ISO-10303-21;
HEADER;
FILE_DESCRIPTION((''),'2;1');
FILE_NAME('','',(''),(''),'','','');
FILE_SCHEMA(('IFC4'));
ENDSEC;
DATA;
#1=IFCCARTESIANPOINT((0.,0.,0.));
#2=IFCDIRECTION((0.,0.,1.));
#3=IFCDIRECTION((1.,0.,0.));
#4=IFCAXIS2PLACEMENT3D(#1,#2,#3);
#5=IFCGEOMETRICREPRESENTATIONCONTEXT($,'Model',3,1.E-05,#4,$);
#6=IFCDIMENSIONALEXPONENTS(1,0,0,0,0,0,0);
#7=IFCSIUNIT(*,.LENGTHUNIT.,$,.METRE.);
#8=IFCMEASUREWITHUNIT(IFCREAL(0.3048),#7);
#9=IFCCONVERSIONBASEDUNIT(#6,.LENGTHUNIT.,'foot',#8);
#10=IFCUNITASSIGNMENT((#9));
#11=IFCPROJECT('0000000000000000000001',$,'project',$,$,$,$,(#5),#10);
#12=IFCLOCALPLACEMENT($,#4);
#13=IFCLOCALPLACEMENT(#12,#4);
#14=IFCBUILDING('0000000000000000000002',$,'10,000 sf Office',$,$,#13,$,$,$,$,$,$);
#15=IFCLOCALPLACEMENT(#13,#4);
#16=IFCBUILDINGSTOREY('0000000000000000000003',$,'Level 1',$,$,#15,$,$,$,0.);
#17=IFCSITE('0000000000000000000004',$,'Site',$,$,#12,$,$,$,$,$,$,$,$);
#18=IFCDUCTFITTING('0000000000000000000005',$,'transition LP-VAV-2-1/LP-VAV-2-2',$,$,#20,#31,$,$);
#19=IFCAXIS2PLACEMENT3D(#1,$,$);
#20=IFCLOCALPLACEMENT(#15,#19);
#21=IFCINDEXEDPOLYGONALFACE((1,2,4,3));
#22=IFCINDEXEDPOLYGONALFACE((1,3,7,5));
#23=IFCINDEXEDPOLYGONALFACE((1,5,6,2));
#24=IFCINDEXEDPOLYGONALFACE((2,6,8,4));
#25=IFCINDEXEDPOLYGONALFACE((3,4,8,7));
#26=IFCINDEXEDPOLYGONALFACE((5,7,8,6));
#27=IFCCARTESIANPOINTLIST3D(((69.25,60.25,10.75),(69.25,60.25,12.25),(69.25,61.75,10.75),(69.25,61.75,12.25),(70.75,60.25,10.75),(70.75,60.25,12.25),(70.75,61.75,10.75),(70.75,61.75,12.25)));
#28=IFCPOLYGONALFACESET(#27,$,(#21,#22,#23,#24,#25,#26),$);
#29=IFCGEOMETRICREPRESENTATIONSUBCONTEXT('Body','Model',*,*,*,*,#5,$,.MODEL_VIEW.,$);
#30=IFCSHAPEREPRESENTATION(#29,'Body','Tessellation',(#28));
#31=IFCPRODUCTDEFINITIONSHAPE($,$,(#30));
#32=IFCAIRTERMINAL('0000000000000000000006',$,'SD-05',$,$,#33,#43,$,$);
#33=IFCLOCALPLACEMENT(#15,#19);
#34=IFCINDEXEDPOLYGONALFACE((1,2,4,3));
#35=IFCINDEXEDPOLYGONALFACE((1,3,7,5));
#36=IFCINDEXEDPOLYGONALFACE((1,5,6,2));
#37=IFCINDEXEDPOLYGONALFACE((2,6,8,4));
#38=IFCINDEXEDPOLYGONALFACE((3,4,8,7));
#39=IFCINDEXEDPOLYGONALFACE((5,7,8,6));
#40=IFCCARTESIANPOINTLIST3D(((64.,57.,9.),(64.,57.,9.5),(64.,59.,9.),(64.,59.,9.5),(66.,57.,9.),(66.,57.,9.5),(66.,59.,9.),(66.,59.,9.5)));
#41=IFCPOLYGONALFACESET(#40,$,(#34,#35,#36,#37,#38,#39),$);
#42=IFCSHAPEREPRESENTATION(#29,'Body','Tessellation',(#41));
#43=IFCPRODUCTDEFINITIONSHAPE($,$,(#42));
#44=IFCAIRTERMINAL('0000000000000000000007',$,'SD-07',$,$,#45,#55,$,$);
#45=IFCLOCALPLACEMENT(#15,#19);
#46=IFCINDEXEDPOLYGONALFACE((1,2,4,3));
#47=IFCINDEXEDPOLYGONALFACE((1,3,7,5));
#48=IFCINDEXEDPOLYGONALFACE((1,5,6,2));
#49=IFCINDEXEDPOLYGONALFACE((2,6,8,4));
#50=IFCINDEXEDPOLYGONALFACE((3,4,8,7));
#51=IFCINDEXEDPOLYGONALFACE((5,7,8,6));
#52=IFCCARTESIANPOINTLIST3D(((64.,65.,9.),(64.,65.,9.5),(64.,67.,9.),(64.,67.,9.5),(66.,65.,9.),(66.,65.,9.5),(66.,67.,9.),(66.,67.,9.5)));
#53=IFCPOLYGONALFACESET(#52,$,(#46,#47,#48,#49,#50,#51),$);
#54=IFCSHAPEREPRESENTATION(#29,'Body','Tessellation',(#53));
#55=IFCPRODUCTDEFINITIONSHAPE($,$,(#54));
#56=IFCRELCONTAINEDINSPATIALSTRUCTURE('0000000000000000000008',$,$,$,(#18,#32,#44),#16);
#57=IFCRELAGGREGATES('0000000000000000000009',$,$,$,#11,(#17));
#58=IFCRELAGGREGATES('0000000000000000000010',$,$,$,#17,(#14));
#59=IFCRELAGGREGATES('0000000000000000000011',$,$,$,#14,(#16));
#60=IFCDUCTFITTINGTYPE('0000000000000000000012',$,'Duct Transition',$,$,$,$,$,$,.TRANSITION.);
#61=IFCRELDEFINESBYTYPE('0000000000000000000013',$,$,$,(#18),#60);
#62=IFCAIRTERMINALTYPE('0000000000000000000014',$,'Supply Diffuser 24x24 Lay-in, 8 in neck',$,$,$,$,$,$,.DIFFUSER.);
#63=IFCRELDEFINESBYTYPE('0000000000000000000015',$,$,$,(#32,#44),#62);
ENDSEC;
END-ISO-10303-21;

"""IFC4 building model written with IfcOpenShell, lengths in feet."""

from ifc_helpers import new_model, entity, si_unit, converted_unit, frame, origin_with_axes, place, context, subcontext, project, spatial, rectangle, extrude, type_object, element, save


model = new_model("IFC4")

# Units and contexts
model_context = context("Model", 3, precision=1e-05, world=origin_with_axes())
body_context = subcontext(model_context, "Body", "Model", "MODEL_VIEW")
ifc_project = project(units=[converted_unit("LENGTHUNIT", "foot", entity("IfcReal", 0.3048), si_unit("LENGTHUNIT", "METRE"), dimensions=[1, 0, 0, 0, 0, 0, 0])], contexts=[model_context])

# Site, building, storey
site_placement = place(None, origin_with_axes())
site = spatial("IfcSite", under=ifc_project, at=site_placement, Name="Site")
building_placement = place(site_placement, origin_with_axes())
building = spatial("IfcBuilding", under=site, at=building_placement, Name="10,000 sf Office")
storey_placement = place(building_placement, origin_with_axes())
storey = spatial("IfcBuildingStorey", under=building, at=storey_placement, Name="Level 1", Elevation=0.0)

# Duct fitting
duct_fitting_type_1 = type_object("IfcDuctFittingType", Name="Duct Transition", PredefinedType="TRANSITION")
duct_fitting_1_placement = place(storey_placement, frame((70.0, 61.0, 10.75), z_axis=(0.0, 0.0, 1.0), x_axis=(1.0, 0.0, 0.0)))
element("IfcDuctFitting", 1, at=duct_fitting_1_placement, inside=storey, type_object=duct_fitting_type_1, Name="transition LP-VAV-2-1/LP-VAV-2-2", context=body_context, shape_type="SweptSolid", body=[
    extrude(rectangle(XDim=1.5, YDim=1.5), None, (0.0, 0.0, 1.0), 1.5),
])

# Air terminals
air_terminal_type = type_object("IfcAirTerminalType", Name="Supply Diffuser 24x24 Lay-in, 8 in neck", PredefinedType="DIFFUSER")
for number, where, z_axis, x_axis, name in (
    (2, (65.0, 58.0, 9.0), (0.0, 0.0, 1.0), (1.0, 0.0, 0.0), "SD-05"),
    (3, (65.0, 66.0, 9.0), (0.0, 0.0, 1.0), (1.0, 0.0, 0.0), "SD-07"),
):
    element("IfcAirTerminal", number, at=place(storey_placement, frame(where, z_axis=z_axis, x_axis=x_axis)), inside=storey, type_object=air_terminal_type, Name=name, context=body_context, shape_type="SweptSolid", body=[
        extrude(rectangle(XDim=2.0, YDim=2.0), None, (0.0, 0.0, 1.0), 0.5),
    ])

save(model, "model.ifc")
